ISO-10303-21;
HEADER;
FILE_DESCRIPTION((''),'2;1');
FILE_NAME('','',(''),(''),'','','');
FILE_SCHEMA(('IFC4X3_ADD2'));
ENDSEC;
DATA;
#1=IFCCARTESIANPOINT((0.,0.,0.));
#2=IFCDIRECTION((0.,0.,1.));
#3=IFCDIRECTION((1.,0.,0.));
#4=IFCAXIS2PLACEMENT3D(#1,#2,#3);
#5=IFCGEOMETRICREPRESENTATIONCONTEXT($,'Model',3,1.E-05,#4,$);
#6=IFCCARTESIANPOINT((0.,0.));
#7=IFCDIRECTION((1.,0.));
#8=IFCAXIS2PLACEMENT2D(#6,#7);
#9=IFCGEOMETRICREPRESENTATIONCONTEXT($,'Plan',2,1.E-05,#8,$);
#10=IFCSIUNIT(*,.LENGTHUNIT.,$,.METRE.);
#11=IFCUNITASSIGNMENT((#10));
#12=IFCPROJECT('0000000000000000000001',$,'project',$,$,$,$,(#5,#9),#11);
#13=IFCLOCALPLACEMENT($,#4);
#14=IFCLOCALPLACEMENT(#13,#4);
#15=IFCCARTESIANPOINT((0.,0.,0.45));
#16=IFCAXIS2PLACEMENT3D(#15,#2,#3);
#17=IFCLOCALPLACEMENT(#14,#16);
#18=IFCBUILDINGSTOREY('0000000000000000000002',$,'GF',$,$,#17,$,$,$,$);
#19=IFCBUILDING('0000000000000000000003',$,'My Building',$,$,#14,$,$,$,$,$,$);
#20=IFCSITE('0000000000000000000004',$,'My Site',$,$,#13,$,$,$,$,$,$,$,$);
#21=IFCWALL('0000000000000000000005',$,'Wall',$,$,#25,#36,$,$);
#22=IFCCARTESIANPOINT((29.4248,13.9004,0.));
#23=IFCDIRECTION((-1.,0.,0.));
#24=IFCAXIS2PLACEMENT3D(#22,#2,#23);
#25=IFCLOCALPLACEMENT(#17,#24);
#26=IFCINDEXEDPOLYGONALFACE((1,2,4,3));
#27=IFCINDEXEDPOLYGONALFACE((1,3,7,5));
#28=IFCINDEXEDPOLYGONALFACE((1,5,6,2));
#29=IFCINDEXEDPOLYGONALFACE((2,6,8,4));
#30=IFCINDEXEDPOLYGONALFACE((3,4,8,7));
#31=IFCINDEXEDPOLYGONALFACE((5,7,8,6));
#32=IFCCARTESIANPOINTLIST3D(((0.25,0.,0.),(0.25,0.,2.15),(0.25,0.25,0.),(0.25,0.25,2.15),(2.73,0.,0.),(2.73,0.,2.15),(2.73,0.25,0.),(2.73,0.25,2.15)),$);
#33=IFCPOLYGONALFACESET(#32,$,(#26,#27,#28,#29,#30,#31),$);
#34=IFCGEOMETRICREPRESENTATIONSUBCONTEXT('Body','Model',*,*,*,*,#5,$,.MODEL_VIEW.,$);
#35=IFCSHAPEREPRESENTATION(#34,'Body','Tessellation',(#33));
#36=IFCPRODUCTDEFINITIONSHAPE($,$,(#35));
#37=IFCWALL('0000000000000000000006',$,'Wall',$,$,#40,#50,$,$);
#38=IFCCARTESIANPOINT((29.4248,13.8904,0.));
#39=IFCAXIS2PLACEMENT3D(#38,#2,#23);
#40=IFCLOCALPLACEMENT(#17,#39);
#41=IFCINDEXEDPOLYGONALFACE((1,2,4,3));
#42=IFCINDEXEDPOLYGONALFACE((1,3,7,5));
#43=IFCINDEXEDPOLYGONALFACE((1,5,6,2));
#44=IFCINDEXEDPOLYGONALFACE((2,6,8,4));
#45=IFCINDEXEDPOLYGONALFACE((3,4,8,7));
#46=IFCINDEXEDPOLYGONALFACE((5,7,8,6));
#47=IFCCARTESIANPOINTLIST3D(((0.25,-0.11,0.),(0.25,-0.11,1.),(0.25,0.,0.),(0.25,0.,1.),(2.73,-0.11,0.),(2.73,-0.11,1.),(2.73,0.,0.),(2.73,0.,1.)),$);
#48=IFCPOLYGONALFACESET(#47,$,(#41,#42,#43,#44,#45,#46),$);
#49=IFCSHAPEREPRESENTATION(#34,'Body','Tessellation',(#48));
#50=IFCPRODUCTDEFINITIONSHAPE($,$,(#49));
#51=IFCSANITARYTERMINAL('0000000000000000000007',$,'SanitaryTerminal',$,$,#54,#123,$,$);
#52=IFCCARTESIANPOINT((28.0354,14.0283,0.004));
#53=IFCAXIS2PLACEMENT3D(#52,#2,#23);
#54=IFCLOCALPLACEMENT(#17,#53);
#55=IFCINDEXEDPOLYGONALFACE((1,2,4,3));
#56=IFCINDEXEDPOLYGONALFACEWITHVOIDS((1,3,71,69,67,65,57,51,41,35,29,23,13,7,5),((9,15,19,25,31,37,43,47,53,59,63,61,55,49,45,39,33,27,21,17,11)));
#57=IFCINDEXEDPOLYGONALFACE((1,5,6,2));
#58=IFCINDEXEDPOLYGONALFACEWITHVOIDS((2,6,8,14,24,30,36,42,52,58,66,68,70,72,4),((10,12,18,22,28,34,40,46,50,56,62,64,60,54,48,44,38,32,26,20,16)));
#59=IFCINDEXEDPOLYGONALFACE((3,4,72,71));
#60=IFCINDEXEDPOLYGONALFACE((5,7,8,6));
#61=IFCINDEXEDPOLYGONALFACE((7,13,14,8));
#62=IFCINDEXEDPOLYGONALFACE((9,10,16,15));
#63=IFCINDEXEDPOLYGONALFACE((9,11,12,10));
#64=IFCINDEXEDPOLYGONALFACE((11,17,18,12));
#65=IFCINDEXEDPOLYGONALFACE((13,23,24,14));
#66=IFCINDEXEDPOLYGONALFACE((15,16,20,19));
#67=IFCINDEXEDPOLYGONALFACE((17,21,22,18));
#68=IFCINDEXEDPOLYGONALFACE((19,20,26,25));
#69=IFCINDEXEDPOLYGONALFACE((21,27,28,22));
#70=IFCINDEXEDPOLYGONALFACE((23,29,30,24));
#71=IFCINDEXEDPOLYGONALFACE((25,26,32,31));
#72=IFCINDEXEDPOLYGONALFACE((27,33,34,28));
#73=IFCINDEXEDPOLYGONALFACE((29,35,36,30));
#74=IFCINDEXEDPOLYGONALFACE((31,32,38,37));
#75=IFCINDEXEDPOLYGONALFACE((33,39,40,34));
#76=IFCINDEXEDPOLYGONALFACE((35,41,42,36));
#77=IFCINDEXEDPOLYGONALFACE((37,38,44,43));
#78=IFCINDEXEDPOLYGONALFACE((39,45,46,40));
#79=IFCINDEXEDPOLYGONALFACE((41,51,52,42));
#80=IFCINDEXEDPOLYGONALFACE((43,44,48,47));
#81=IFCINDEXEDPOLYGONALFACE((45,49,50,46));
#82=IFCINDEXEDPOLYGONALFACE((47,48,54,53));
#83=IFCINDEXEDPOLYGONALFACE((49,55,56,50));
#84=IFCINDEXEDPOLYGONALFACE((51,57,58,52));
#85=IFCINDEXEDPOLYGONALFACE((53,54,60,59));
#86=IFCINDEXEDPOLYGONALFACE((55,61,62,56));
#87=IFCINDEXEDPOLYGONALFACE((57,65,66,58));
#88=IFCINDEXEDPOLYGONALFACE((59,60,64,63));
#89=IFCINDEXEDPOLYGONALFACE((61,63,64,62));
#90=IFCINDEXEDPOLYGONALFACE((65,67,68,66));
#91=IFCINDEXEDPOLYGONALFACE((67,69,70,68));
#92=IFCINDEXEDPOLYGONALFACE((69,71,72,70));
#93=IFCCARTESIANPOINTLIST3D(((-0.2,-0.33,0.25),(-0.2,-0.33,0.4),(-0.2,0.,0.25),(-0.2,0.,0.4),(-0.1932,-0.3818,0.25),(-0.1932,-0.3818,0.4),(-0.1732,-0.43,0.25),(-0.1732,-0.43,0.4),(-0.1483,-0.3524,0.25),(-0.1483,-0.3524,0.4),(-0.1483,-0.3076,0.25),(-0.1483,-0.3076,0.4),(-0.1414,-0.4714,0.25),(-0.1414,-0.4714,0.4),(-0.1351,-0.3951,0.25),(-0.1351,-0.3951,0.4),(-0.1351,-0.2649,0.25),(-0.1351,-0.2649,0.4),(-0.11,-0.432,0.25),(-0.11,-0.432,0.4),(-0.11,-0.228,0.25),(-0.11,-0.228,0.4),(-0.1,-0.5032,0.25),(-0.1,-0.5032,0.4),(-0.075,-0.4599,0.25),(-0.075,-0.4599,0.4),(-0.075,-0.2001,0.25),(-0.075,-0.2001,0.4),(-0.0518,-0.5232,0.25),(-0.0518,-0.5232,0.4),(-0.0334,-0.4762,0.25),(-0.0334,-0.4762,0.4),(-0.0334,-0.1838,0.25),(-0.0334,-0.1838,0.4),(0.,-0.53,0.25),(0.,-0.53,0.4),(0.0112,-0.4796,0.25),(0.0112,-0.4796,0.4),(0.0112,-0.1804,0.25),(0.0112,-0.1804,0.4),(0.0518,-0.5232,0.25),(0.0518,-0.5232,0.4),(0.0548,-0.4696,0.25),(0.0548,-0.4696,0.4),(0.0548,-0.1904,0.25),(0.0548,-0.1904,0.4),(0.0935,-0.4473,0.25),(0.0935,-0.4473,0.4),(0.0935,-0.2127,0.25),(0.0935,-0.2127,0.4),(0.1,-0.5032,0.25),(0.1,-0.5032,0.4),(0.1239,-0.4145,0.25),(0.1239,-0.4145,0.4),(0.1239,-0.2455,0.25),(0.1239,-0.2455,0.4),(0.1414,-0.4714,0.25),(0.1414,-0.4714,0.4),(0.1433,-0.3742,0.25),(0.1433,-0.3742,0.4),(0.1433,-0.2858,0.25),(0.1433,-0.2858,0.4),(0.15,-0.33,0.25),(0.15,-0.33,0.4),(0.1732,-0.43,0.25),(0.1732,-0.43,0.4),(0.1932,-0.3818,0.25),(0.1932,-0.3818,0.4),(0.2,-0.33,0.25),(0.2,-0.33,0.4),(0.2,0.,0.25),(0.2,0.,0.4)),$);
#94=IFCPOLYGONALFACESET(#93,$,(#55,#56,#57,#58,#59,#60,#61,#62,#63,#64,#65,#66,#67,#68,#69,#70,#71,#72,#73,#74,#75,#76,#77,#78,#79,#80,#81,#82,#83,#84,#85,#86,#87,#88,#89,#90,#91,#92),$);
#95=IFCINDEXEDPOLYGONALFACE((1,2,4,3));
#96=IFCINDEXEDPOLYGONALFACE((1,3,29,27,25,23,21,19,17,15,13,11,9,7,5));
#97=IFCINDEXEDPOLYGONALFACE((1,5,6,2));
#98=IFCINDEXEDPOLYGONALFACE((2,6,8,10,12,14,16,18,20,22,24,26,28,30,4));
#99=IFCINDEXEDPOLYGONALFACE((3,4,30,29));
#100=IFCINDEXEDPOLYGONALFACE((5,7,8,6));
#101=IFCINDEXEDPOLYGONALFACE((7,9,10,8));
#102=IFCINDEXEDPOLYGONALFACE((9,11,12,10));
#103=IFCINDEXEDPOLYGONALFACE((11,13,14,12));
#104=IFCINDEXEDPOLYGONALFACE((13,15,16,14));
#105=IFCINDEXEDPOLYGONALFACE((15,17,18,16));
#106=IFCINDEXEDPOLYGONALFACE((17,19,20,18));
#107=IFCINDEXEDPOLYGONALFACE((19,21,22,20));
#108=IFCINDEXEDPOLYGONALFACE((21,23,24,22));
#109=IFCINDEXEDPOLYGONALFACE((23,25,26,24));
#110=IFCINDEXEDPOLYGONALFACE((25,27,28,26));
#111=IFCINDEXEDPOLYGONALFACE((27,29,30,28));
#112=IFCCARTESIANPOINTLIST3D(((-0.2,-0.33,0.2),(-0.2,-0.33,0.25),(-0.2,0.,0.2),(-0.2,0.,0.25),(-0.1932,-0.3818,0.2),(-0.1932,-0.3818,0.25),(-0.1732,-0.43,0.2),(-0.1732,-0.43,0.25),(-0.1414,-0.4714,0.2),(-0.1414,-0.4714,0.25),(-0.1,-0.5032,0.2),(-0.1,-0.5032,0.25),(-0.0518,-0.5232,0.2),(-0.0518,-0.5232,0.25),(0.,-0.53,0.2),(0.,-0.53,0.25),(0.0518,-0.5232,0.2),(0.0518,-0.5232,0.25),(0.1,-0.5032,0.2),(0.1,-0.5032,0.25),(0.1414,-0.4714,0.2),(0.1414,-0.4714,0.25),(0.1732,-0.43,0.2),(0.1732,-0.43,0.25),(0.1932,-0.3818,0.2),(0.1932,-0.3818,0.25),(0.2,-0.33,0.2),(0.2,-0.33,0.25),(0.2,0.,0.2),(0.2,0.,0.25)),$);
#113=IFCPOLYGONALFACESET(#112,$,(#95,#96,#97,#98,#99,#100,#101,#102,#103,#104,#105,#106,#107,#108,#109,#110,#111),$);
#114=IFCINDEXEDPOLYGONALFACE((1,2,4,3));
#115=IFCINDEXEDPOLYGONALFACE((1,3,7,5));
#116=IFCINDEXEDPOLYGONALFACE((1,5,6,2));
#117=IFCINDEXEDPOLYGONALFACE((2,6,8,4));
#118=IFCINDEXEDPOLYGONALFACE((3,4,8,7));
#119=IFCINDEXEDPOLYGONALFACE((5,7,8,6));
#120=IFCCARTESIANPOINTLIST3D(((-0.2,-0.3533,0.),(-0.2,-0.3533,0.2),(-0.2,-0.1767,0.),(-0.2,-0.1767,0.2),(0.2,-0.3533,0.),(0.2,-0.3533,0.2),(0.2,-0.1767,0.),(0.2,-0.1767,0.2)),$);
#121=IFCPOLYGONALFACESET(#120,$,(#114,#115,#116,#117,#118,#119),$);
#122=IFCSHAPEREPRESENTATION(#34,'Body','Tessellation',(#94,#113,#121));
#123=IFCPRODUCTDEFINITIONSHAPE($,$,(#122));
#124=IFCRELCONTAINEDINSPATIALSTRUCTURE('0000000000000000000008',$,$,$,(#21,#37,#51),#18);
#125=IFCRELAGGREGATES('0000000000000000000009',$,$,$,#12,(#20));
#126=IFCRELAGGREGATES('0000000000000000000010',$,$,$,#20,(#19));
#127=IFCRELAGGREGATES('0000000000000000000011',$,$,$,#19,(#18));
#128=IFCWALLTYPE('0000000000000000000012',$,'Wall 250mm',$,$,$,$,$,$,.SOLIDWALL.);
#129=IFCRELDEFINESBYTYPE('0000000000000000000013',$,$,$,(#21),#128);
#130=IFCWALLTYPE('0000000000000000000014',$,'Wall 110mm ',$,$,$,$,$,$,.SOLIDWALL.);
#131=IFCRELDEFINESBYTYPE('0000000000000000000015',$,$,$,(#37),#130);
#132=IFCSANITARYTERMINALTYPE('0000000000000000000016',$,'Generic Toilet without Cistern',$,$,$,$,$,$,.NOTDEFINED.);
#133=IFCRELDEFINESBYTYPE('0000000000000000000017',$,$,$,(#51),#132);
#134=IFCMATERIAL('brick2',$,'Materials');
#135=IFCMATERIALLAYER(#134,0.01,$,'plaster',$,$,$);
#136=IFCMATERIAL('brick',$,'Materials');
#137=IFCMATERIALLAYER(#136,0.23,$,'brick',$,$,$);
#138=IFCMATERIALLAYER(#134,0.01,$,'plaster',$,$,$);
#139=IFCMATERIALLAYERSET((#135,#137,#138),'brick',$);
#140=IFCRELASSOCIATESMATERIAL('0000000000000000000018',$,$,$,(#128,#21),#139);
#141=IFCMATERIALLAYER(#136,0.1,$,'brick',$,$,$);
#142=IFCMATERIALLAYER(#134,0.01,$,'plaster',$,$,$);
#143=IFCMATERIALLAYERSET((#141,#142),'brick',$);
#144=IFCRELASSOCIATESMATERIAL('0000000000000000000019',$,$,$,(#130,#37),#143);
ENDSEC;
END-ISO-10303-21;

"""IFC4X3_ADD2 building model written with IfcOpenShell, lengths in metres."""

from ifc_helpers import new_model, entity, si_unit, frame, frame_2d, origin_with_axes, origin_2d_with_axis, place, context, subcontext, project, spatial, line, arc, indexed_curve, circle_curve, outline, extrude, shape, source, transform, mapped, material, layer, layer_set, layer_usage, type_object, type_shapes, element, save


model = new_model("IFC4X3_ADD2")

# Units and contexts
model_context = context("Model", 3, precision=1e-05, world=origin_with_axes())
plan_context = context("Plan", 2, precision=1e-05, world=origin_2d_with_axis())
body_context_1 = subcontext(model_context, "Body", "Model", "MODEL_VIEW")
body_context_2 = subcontext(plan_context, "Body", "Plan", "PLAN_VIEW")
ifc_project = project(units=[si_unit("LENGTHUNIT", "METRE")], contexts=[model_context, plan_context])

# Site, building, storey
site_placement = place(None, origin_with_axes())
site = spatial("IfcSite", under=ifc_project, at=site_placement, Name="My Site")
building_placement = place(site_placement, origin_with_axes())
building = spatial("IfcBuilding", under=site, at=building_placement, Name="My Building")
storey_placement = place(building_placement, frame((0.0, 0.0, 0.45), z_axis=(0.0, 0.0, 1.0), x_axis=(1.0, 0.0, 0.0)))
storey = spatial("IfcBuildingStorey", under=building, at=storey_placement, Name="GF")

# Shared definitions
ifc_material_1 = material(Name="brick2", Category="Materials")
ifc_layer_1 = layer(ifc_material_1, 0.01, Name="plaster")
ifc_material_2 = material(Name="brick", Category="Materials")
ifc_layer_2 = layer(ifc_material_2, 0.23, Name="brick")
ifc_layer_3 = layer(ifc_material_1, 0.01, Name="plaster")
ifc_layer_set_1 = layer_set([ifc_layer_1, ifc_layer_2, ifc_layer_3], Name="brick")
wall_type_1 = type_object("IfcWallType", Name="Wall 250mm", PredefinedType="SOLIDWALL", material=ifc_layer_set_1)

# Wall
ifc_layer_usage_1 = layer_usage(ifc_layer_set_1, "AXIS2", "POSITIVE", 0.0)
wall_1_placement = place(storey_placement, frame((29.4248, 13.9004, 0.0), z_axis=(0.0, 0.0, 1.0), x_axis=(-1.0, 0.0, 0.0)))
element("IfcWall", 1, at=wall_1_placement, inside=storey, type_object=wall_type_1, material=ifc_layer_usage_1, Name="Wall", context=body_context_1, shape_type="SweptSolid", body=[
    extrude(outline(indexed_curve([(0.25, 0.0), (0.25, 0.25), (2.73, 0.25), (2.73, 0.0)], segments=[line(1, 2, 3, 4, 1)])), origin_with_axes(), (0.0, 0.0, 1.0), 2.15),
])

# Wall
ifc_layer_4 = layer(ifc_material_2, 0.1, Name="brick")
ifc_layer_5 = layer(ifc_material_1, 0.01, Name="plaster")
ifc_layer_set_2 = layer_set([ifc_layer_4, ifc_layer_5], Name="brick")
wall_type_2 = type_object("IfcWallType", Name="Wall 110mm ", PredefinedType="SOLIDWALL", material=ifc_layer_set_2)
ifc_layer_usage_2 = layer_usage(ifc_layer_set_2, "AXIS2", "NEGATIVE", 0.0)
wall_2_placement = place(storey_placement, frame((29.4248, 13.8904, 0.0), z_axis=(0.0, 0.0, 1.0), x_axis=(-1.0, 0.0, 0.0)))
element("IfcWall", 2, at=wall_2_placement, inside=storey, type_object=wall_type_2, material=ifc_layer_usage_2, Name="Wall", context=body_context_1, shape_type="SweptSolid", body=[
    extrude(outline(indexed_curve([(0.25, -0.11), (0.25, 0.0), (2.73, 0.0), (2.73, -0.11)], segments=[line(1, 2, 3, 4, 1)])), origin_with_axes(), (0.0, 0.0, 1.0), 1.0),
])

# Sanitary terminal
sanitary_terminal_type_1 = type_object("IfcSanitaryTerminalType", Name="Generic Toilet without Cistern", PredefinedType="NOTDEFINED")
shared_shape_1 = source(origin_with_axes(), body_context_1, "Body", "SweptSolid", [
    extrude(outline(indexed_curve([(-0.2, 0.0), (0.2, 0.0), (0.2, -0.33), (0.1414, -0.4714), (0.0, -0.53), (-0.1414, -0.4714), (-0.2, -0.33)], segments=[line(1, 2), line(2, 3), arc(3, 4, 5), arc(5, 6, 7), line(7, 1)]), holes=[circle_curve(frame_2d((0.0, -0.33)), 0.15)]), frame((0.0, 0.0, 0.25), z_axis=(0.0, 0.0, 1.0), x_axis=(1.0, 0.0, 0.0)), (0.0, 0.0, 1.0), 0.15),
    extrude(outline(indexed_curve([(-0.2, 0.0), (0.2, 0.0), (0.2, -0.33), (0.1414, -0.4714), (0.0, -0.53), (-0.1414, -0.4714), (-0.2, -0.33)], segments=[line(1, 2), line(2, 3), arc(3, 4, 5), arc(5, 6, 7), line(7, 1)])), frame((0.0, 0.0, 0.2), z_axis=(0.0, 0.0, 1.0), x_axis=(1.0, 0.0, 0.0)), (0.0, 0.0, 1.0), 0.05),
    extrude(outline(indexed_curve([(-0.2, -0.1767), (0.2, -0.1767), (0.2, -0.3533), (-0.2, -0.3533)], segments=[line(1, 2, 3, 4, 1)])), origin_with_axes(), (0.0, 0.0, 1.0), 0.2),
])
shared_shape_2 = source(origin_with_axes(), body_context_2, "Body", "GeometricSet", [
    entity("IfcGeometricCurveSet", [entity("IfcIndexedPolyCurve", entity("IfcCartesianPointList2D", [[-0.1068, -0.124], [-0.0957, -0.1129], [-0.0804, -0.1088], [0.0804, -0.1088], [0.0957, -0.1129], [0.1068, -0.124], [0.1109, -0.1393], [0.1109, -0.3476], [0.1025, -0.3926], [0.0784, -0.4308], [0.0424, -0.4563], [0.0, -0.4652], [-0.0424, -0.4563], [-0.0784, -0.4308], [-0.1025, -0.3926], [-0.1109, -0.3476], [-0.1109, -0.1393]]), [entity("IfcLineIndex", [1, 2, 3, 4, 5, 6, 7, 8, 9, 10, 11, 12, 13, 14, 15, 16, 17, 1])]), entity("IfcIndexedPolyCurve", entity("IfcCartesianPointList2D", [[-0.1962, -0.2314], [-0.1848, -0.301], [-0.1764, -0.3339], [-0.1663, -0.3651], [-0.1546, -0.3944], [-0.1414, -0.4213], [-0.1269, -0.4458], [-0.1111, -0.4675], [-0.0943, -0.4862], [-0.0765, -0.5018], [-0.0581, -0.514], [-0.039, -0.5229], [-0.0196, -0.5282], [0.0, -0.53], [0.0196, -0.5282], [0.039, -0.5229], [0.0581, -0.514], [0.0765, -0.5018], [0.0943, -0.4862], [0.1111, -0.4675], [0.1269, -0.4458], [0.1414, -0.4213], [0.1546, -0.3944], [0.1663, -0.3651], [0.1764, -0.3339], [0.1848, -0.301], [0.1962, -0.2314], [0.2, -0.159], [0.1872, 0.0], [-0.1872, 0.0], [-0.2, -0.159]]), [entity("IfcLineIndex", [1, 2, 3, 4, 5, 6, 7, 8, 9, 10, 11, 12, 13, 14, 15, 16, 17, 18, 19, 20, 21, 22, 23, 24, 25, 26, 27, 28, 29, 30, 31, 1])])]),
])
type_shapes(sanitary_terminal_type_1, [shared_shape_1, shared_shape_2])
for number, where, z_axis, x_axis, name in (
    (3, (28.0354, 14.0283, 0.004), (0.0, 0.0, 1.0), (-1.0, 0.0, 0.0), "SanitaryTerminal"),
):
    element("IfcSanitaryTerminal", number, at=place(storey_placement, frame(where, z_axis=z_axis, x_axis=x_axis)), inside=storey, type_object=sanitary_terminal_type_1, Name=name, shapes=[
        shape(body_context_1, "Body", "MappedRepresentation", [mapped(shared_shape_1, transform((0.0, 0.0, 0.0), x_axis=(1.0, 0.0, 0.0), y_axis=(0.0, 1.0, 0.0), z_axis=(0.0, 0.0, 1.0), scale=1.0))]),
        shape(body_context_2, "Body", "MappedRepresentation", [mapped(shared_shape_2, transform((0.0, 0.0, 0.0), x_axis=(1.0, 0.0, 0.0), y_axis=(0.0, 1.0, 0.0), z_axis=(0.0, 0.0, 1.0), scale=1.0))]),
    ])

save(model, "model.ifc")
